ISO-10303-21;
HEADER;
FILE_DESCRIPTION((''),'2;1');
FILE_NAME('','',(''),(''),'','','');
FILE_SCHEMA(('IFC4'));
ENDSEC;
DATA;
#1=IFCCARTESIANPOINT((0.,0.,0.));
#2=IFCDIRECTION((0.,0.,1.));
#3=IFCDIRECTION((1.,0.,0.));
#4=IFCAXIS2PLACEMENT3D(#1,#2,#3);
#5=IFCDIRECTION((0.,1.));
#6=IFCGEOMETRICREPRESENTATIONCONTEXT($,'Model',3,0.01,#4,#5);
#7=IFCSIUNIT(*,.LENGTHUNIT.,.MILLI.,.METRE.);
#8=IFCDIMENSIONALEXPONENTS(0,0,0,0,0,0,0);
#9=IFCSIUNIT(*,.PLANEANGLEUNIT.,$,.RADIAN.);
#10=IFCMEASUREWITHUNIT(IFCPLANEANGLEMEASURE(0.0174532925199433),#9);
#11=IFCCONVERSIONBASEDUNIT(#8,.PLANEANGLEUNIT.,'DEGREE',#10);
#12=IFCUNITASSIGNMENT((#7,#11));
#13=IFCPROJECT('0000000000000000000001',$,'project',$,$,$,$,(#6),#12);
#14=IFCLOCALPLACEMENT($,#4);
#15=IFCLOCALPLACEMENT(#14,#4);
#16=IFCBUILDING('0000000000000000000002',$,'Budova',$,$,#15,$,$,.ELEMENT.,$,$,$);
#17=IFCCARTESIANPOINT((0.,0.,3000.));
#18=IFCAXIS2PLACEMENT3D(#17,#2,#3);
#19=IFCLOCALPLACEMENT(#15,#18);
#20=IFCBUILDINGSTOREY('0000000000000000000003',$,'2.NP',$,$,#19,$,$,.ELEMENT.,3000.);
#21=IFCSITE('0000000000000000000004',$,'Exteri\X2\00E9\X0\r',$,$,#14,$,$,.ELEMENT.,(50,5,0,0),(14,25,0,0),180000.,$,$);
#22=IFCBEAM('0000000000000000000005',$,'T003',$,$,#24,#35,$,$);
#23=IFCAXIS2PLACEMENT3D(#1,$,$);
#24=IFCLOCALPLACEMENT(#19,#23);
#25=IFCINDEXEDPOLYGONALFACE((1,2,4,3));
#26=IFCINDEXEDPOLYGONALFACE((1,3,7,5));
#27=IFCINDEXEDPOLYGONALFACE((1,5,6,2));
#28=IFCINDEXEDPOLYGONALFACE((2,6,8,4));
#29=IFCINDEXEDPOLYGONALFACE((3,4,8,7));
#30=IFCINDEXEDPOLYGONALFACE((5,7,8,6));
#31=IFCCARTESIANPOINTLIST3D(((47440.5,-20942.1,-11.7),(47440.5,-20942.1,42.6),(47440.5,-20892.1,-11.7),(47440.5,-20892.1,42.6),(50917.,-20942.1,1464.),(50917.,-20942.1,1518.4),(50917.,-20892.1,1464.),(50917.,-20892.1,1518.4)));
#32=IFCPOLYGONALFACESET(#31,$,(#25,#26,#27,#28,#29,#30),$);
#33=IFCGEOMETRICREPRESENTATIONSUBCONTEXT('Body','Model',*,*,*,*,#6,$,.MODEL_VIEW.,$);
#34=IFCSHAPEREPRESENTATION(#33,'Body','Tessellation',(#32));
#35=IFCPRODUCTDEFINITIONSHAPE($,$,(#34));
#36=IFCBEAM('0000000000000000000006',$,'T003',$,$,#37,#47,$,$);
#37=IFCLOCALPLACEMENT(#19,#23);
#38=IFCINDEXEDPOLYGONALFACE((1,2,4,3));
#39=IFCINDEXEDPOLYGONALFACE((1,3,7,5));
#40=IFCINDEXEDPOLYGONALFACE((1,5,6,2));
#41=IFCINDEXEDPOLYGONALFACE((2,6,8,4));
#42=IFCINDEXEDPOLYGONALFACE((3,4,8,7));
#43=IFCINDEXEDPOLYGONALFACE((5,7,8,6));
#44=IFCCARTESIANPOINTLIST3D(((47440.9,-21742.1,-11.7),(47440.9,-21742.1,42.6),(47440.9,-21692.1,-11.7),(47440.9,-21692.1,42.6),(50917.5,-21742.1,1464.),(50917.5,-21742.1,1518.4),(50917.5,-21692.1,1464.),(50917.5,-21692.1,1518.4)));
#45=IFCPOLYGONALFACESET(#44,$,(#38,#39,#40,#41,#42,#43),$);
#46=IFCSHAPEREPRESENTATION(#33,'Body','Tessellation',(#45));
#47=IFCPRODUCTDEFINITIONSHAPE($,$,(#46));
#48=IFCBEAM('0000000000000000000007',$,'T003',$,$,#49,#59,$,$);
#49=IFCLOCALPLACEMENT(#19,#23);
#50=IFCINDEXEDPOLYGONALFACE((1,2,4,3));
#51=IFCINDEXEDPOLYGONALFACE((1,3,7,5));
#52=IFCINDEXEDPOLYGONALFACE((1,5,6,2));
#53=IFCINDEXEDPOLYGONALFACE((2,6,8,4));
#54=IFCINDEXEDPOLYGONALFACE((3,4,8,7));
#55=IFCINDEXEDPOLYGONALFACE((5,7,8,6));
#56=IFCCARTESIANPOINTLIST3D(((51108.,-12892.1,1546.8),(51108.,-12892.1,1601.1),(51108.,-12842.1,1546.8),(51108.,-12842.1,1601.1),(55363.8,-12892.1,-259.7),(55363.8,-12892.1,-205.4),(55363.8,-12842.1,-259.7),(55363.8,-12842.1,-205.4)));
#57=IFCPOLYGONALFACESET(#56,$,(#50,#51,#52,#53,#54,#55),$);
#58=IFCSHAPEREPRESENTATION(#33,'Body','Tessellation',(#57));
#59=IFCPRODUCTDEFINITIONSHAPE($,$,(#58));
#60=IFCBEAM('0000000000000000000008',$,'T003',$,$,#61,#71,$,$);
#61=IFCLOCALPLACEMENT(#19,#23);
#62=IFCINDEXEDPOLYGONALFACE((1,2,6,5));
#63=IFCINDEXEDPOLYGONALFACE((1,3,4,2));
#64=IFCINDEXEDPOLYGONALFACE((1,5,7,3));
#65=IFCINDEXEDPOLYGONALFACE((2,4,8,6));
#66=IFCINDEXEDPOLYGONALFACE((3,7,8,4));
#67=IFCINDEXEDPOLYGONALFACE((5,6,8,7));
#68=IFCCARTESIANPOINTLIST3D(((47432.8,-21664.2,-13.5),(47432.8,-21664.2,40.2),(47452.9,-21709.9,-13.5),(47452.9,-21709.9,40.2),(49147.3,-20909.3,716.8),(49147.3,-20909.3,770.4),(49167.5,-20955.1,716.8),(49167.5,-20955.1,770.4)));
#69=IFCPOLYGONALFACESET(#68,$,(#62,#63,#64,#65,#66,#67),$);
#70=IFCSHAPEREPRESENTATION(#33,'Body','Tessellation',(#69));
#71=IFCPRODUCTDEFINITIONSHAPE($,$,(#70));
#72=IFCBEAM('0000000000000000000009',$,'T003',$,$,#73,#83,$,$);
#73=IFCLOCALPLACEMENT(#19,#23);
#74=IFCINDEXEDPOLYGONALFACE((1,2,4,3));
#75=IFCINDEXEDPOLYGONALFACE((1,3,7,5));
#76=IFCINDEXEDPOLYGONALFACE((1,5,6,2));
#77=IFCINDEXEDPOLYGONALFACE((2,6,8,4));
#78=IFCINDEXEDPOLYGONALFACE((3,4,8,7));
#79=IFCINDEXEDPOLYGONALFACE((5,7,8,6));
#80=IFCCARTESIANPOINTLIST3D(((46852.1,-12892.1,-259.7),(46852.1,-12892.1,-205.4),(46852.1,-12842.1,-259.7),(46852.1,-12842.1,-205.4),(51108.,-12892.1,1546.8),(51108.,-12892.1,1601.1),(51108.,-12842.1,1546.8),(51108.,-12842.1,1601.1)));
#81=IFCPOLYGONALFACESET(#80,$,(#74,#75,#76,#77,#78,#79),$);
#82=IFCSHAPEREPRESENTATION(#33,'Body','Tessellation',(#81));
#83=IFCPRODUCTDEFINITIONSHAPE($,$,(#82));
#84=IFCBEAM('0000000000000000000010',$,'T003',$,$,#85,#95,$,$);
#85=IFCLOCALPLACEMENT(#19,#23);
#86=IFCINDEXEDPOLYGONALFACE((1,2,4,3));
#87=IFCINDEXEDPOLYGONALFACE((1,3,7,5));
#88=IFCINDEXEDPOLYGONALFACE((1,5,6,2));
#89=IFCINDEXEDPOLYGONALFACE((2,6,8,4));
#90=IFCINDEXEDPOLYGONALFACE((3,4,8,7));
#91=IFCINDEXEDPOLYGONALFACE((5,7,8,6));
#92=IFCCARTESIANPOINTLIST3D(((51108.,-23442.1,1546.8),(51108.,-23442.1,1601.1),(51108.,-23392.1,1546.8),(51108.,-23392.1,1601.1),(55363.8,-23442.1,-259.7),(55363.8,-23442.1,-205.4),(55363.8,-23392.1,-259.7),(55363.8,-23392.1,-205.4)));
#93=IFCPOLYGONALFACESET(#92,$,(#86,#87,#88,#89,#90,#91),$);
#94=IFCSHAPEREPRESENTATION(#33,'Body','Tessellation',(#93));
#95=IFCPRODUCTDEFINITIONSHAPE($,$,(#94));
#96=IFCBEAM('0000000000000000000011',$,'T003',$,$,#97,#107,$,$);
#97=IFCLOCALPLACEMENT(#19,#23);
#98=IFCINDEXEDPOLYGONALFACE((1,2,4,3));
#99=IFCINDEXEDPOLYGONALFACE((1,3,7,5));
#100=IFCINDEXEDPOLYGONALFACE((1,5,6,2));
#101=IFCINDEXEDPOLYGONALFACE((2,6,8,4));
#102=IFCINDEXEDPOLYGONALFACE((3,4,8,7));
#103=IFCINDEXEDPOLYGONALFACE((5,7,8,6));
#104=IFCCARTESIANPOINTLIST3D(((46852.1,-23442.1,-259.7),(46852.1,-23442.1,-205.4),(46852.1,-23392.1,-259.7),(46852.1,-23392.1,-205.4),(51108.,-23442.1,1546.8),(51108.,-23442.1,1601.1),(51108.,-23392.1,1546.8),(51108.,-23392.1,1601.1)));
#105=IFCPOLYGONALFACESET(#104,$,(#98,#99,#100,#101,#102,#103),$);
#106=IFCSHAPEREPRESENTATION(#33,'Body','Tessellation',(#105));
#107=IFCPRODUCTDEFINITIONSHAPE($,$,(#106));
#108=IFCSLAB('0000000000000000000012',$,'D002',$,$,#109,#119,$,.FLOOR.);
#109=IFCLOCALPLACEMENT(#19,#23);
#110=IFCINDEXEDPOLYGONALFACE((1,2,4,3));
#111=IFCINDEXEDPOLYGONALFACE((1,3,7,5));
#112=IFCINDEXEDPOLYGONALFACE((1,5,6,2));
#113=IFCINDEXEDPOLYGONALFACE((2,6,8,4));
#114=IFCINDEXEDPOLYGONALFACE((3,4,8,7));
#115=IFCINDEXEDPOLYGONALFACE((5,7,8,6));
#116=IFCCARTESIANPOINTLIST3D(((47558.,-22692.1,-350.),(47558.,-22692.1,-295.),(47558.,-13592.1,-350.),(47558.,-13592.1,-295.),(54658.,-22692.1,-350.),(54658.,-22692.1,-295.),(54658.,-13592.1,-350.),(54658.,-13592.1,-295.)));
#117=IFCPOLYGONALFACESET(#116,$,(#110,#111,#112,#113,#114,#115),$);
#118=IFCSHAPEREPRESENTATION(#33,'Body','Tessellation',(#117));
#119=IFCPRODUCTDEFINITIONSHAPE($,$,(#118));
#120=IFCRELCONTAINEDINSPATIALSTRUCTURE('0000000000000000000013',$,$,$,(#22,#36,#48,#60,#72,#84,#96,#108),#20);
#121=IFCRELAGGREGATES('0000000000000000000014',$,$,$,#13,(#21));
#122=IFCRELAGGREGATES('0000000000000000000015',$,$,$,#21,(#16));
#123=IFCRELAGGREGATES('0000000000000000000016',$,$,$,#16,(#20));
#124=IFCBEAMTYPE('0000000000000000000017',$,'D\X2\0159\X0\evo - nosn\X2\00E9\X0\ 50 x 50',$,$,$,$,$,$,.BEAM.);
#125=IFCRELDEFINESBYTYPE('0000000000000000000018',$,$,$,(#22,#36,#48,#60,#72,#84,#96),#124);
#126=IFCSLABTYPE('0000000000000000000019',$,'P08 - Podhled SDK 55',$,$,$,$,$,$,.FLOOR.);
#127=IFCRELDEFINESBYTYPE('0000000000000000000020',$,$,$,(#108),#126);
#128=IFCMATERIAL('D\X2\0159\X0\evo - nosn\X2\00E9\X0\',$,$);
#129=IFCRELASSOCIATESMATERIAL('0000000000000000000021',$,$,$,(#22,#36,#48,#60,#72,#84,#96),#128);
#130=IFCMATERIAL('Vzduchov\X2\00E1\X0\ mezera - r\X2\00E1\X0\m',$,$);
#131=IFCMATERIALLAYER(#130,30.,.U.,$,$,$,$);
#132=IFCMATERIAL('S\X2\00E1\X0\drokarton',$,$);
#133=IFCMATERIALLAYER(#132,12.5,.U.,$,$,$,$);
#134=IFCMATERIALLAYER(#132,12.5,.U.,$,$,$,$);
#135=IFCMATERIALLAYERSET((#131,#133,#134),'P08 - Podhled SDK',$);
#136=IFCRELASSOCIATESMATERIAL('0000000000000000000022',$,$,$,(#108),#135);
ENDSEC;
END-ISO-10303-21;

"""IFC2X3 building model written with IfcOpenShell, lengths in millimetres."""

from ifc_helpers import new_model, entity, si_unit, converted_unit, direction, frame, frame_2d, origin_with_axes, place, context, subcontext, project, spatial, polyline, rectangle, outline, extrude, clip, halfspace, material, layer, layer_set, layer_usage, type_object, element, save


model = new_model("IFC2X3")

# Units and contexts
model_context = context("Model", 3, precision=0.01, world=origin_with_axes(), true_north=direction((0.0, 1.0)))
body_context = subcontext(model_context, "Body", "Model", "MODEL_VIEW")
ifc_project = project(units=[si_unit("LENGTHUNIT", "METRE", prefix="MILLI"), converted_unit("PLANEANGLEUNIT", "DEGREE", entity("IfcPlaneAngleMeasure", 0.0174532925199433), si_unit("PLANEANGLEUNIT", "RADIAN"), dimensions=[0, 0, 0, 0, 0, 0, 0])], contexts=[model_context])

# Site, building, storey
site_placement = place(None, origin_with_axes())
site = spatial("IfcSite", under=ifc_project, at=site_placement, Name="Exteriér", CompositionType="ELEMENT", RefLatitude=(50, 5, 0, 0), RefLongitude=(14, 25, 0, 0), RefElevation=180000.0)
building_placement = place(site_placement, origin_with_axes())
building = spatial("IfcBuilding", under=site, at=building_placement, Name="Budova", CompositionType="ELEMENT")
storey_placement = place(building_placement, frame((0.0, 0.0, 3000.0), z_axis=(0.0, 0.0, 1.0), x_axis=(1.0, 0.0, 0.0)))
storey = spatial("IfcBuildingStorey", under=building, at=storey_placement, Name="2.NP", CompositionType="ELEMENT", Elevation=3000.0)

# Beams
ifc_material_1 = material(Name="Dřevo - nosné")
beam_type = type_object("IfcBeamType", Name="Dřevo - nosné 50 x 50", PredefinedType="BEAM")
for number, where, z_axis, x_axis, name in (
    (1, (47440.5, -20917.1, 42.6), (0.0, 0.0, 1.0), (0.0, -1.0, 0.0), "T003"),
    (2, (47440.9, -21717.1, 42.6), (0.0, 0.0, 1.0), (0.0, -1.0, 0.0), "T003"),
):
    element("IfcBeam", number, at=place(storey_placement, frame(where, z_axis=z_axis, x_axis=x_axis)), inside=storey, type_object=beam_type, material=ifc_material_1, Name=name, context=body_context, shape_type="Clipping", body=[
        clip(clip(extrude(rectangle(XDim=50.0, YDim=50.0, at=frame_2d((-25.0, 0.0), x_axis=(1.0, 0.0))), frame((0.0, -27.6, -11.7), z_axis=(0.0, 0.920505, 0.390731), x_axis=(0.0, -0.390731, 0.920505)), (0.0, 0.0, 1.0), 3836.8), halfspace(frame((0.0, 0.0, 0.0), z_axis=(0.0, 1.0, 0.0), x_axis=(0.0, 0.0, 1.0)), True)), halfspace(frame((0.0, 3476.5, 0.0), z_axis=(0.0, -1.0, 0.0), x_axis=(0.0, 0.0, -1.0)), True)),
    ])
beam_1_placement = place(storey_placement, frame((55363.8, -12867.1, -205.4), z_axis=(0.0, 0.0, 1.0), x_axis=(0.0, 1.0, 0.0)))
element("IfcBeam", 3, at=beam_1_placement, inside=storey, type_object=beam_type, material=ifc_material_1, Name="T003", context=body_context, shape_type="Clipping", body=[
    clip(clip(extrude(rectangle(XDim=50.0, YDim=50.0, at=frame_2d((-25.0, 0.0), x_axis=(1.0, 0.0))), frame((0.0, -27.6, -11.7), z_axis=(0.0, 0.920505, 0.390731), x_axis=(0.0, -0.390731, 0.920505)), (0.0, 0.0, 1.0), 4683.4), halfspace(frame((0.0, 0.0, 0.0), z_axis=(0.0, 1.0, 0.0), x_axis=(0.0, 0.0, 1.0)), True)), halfspace(frame((0.0, 4255.9, 0.0), z_axis=(0.0, -1.0, 0.0), x_axis=(0.0, 0.0, -1.0)), True)),
])
beam_2_placement = place(storey_placement, frame((47442.9, -21687.0, 40.2), z_axis=(0.0, 0.0, 1.0), x_axis=(0.402939, -0.915227, 0.0)))
element("IfcBeam", 4, at=beam_2_placement, inside=storey, type_object=beam_type, material=ifc_material_1, Name="T003", context=body_context, shape_type="Clipping", body=[
    clip(clip(extrude(rectangle(XDim=50.0, YDim=50.0, at=frame_2d((-25.0, 0.0), x_axis=(1.0, 0.0))), frame((0.0, -25.7, -10.0), z_axis=(0.0, 0.931709, 0.363205), x_axis=(0.0, -0.363205, 0.931709)), (0.0, 0.0, 1.0), 2065.8), halfspace(frame((0.0, 0.0, 0.0), z_axis=(0.0, 1.0, 0.0), x_axis=(0.0, 0.0, 1.0)), True)), halfspace(frame((0.0, 1873.3, 0.0), z_axis=(0.0, -1.0, 0.0), x_axis=(0.0, 0.0, -1.0)), True)),
])
for number, where, z_axis, x_axis, name in (
    (5, (46852.1, -12867.1, -205.4), (0.0, 0.0, 1.0), (0.0, -1.0, 0.0), "T003"),
    (6, (55363.8, -23417.1, -205.4), (0.0, 0.0, 1.0), (0.0, 1.0, 0.0), "T003"),
    (7, (46852.1, -23417.1, -205.4), (0.0, 0.0, 1.0), (0.0, -1.0, 0.0), "T003"),
):
    element("IfcBeam", number, at=place(storey_placement, frame(where, z_axis=z_axis, x_axis=x_axis)), inside=storey, type_object=beam_type, material=ifc_material_1, Name=name, context=body_context, shape_type="Clipping", body=[
        clip(clip(extrude(rectangle(XDim=50.0, YDim=50.0, at=frame_2d((-25.0, 0.0), x_axis=(1.0, 0.0))), frame((0.0, -27.6, -11.7), z_axis=(0.0, 0.920505, 0.390731), x_axis=(0.0, -0.390731, 0.920505)), (0.0, 0.0, 1.0), 4683.4), halfspace(frame((0.0, 0.0, 0.0), z_axis=(0.0, 1.0, 0.0), x_axis=(0.0, 0.0, 1.0)), True)), halfspace(frame((0.0, 4255.9, 0.0), z_axis=(0.0, -1.0, 0.0), x_axis=(0.0, 0.0, -1.0)), True)),
    ])

# Slab
ifc_material_2 = material(Name="Vzduchová mezera - rám")
ifc_layer_1 = layer(ifc_material_2, 30.0, ventilated="UNKNOWN")
ifc_material_3 = material(Name="Sádrokarton")
ifc_layer_2 = layer(ifc_material_3, 12.5, ventilated="UNKNOWN")
ifc_layer_3 = layer(ifc_material_3, 12.5, ventilated="UNKNOWN")
ifc_layer_set_1 = layer_set([ifc_layer_1, ifc_layer_2, ifc_layer_3], Name="P08 - Podhled SDK")
ifc_layer_usage_1 = layer_usage(ifc_layer_set_1, "AXIS3", "NEGATIVE", 55.0)
slab_type_1 = type_object("IfcSlabType", Name="P08 - Podhled SDK 55", PredefinedType="FLOOR")
slab_1_placement = place(storey_placement, frame((47558.0, -13592.1, -295.0), z_axis=(0.0, 0.0, 1.0), x_axis=(1.0, 0.0, 0.0)))
element("IfcSlab", 8, at=slab_1_placement, inside=storey, type_object=slab_type_1, material=ifc_layer_usage_1, Name="D002", PredefinedType="FLOOR", context=body_context, shape_type="SweptSolid", body=[
    extrude(outline(polyline([(0.0, 0.0), (0.0, -9100.0), (7100.0, -9100.0), (7100.0, 0.0), (0.0, 0.0)])), frame((0.0, 0.0, -55.0), z_axis=(0.0, 0.0, 1.0), x_axis=(1.0, 0.0, 0.0)), (0.0, 0.0, 1.0), 55.0),
])

save(model, "model.ifc")
